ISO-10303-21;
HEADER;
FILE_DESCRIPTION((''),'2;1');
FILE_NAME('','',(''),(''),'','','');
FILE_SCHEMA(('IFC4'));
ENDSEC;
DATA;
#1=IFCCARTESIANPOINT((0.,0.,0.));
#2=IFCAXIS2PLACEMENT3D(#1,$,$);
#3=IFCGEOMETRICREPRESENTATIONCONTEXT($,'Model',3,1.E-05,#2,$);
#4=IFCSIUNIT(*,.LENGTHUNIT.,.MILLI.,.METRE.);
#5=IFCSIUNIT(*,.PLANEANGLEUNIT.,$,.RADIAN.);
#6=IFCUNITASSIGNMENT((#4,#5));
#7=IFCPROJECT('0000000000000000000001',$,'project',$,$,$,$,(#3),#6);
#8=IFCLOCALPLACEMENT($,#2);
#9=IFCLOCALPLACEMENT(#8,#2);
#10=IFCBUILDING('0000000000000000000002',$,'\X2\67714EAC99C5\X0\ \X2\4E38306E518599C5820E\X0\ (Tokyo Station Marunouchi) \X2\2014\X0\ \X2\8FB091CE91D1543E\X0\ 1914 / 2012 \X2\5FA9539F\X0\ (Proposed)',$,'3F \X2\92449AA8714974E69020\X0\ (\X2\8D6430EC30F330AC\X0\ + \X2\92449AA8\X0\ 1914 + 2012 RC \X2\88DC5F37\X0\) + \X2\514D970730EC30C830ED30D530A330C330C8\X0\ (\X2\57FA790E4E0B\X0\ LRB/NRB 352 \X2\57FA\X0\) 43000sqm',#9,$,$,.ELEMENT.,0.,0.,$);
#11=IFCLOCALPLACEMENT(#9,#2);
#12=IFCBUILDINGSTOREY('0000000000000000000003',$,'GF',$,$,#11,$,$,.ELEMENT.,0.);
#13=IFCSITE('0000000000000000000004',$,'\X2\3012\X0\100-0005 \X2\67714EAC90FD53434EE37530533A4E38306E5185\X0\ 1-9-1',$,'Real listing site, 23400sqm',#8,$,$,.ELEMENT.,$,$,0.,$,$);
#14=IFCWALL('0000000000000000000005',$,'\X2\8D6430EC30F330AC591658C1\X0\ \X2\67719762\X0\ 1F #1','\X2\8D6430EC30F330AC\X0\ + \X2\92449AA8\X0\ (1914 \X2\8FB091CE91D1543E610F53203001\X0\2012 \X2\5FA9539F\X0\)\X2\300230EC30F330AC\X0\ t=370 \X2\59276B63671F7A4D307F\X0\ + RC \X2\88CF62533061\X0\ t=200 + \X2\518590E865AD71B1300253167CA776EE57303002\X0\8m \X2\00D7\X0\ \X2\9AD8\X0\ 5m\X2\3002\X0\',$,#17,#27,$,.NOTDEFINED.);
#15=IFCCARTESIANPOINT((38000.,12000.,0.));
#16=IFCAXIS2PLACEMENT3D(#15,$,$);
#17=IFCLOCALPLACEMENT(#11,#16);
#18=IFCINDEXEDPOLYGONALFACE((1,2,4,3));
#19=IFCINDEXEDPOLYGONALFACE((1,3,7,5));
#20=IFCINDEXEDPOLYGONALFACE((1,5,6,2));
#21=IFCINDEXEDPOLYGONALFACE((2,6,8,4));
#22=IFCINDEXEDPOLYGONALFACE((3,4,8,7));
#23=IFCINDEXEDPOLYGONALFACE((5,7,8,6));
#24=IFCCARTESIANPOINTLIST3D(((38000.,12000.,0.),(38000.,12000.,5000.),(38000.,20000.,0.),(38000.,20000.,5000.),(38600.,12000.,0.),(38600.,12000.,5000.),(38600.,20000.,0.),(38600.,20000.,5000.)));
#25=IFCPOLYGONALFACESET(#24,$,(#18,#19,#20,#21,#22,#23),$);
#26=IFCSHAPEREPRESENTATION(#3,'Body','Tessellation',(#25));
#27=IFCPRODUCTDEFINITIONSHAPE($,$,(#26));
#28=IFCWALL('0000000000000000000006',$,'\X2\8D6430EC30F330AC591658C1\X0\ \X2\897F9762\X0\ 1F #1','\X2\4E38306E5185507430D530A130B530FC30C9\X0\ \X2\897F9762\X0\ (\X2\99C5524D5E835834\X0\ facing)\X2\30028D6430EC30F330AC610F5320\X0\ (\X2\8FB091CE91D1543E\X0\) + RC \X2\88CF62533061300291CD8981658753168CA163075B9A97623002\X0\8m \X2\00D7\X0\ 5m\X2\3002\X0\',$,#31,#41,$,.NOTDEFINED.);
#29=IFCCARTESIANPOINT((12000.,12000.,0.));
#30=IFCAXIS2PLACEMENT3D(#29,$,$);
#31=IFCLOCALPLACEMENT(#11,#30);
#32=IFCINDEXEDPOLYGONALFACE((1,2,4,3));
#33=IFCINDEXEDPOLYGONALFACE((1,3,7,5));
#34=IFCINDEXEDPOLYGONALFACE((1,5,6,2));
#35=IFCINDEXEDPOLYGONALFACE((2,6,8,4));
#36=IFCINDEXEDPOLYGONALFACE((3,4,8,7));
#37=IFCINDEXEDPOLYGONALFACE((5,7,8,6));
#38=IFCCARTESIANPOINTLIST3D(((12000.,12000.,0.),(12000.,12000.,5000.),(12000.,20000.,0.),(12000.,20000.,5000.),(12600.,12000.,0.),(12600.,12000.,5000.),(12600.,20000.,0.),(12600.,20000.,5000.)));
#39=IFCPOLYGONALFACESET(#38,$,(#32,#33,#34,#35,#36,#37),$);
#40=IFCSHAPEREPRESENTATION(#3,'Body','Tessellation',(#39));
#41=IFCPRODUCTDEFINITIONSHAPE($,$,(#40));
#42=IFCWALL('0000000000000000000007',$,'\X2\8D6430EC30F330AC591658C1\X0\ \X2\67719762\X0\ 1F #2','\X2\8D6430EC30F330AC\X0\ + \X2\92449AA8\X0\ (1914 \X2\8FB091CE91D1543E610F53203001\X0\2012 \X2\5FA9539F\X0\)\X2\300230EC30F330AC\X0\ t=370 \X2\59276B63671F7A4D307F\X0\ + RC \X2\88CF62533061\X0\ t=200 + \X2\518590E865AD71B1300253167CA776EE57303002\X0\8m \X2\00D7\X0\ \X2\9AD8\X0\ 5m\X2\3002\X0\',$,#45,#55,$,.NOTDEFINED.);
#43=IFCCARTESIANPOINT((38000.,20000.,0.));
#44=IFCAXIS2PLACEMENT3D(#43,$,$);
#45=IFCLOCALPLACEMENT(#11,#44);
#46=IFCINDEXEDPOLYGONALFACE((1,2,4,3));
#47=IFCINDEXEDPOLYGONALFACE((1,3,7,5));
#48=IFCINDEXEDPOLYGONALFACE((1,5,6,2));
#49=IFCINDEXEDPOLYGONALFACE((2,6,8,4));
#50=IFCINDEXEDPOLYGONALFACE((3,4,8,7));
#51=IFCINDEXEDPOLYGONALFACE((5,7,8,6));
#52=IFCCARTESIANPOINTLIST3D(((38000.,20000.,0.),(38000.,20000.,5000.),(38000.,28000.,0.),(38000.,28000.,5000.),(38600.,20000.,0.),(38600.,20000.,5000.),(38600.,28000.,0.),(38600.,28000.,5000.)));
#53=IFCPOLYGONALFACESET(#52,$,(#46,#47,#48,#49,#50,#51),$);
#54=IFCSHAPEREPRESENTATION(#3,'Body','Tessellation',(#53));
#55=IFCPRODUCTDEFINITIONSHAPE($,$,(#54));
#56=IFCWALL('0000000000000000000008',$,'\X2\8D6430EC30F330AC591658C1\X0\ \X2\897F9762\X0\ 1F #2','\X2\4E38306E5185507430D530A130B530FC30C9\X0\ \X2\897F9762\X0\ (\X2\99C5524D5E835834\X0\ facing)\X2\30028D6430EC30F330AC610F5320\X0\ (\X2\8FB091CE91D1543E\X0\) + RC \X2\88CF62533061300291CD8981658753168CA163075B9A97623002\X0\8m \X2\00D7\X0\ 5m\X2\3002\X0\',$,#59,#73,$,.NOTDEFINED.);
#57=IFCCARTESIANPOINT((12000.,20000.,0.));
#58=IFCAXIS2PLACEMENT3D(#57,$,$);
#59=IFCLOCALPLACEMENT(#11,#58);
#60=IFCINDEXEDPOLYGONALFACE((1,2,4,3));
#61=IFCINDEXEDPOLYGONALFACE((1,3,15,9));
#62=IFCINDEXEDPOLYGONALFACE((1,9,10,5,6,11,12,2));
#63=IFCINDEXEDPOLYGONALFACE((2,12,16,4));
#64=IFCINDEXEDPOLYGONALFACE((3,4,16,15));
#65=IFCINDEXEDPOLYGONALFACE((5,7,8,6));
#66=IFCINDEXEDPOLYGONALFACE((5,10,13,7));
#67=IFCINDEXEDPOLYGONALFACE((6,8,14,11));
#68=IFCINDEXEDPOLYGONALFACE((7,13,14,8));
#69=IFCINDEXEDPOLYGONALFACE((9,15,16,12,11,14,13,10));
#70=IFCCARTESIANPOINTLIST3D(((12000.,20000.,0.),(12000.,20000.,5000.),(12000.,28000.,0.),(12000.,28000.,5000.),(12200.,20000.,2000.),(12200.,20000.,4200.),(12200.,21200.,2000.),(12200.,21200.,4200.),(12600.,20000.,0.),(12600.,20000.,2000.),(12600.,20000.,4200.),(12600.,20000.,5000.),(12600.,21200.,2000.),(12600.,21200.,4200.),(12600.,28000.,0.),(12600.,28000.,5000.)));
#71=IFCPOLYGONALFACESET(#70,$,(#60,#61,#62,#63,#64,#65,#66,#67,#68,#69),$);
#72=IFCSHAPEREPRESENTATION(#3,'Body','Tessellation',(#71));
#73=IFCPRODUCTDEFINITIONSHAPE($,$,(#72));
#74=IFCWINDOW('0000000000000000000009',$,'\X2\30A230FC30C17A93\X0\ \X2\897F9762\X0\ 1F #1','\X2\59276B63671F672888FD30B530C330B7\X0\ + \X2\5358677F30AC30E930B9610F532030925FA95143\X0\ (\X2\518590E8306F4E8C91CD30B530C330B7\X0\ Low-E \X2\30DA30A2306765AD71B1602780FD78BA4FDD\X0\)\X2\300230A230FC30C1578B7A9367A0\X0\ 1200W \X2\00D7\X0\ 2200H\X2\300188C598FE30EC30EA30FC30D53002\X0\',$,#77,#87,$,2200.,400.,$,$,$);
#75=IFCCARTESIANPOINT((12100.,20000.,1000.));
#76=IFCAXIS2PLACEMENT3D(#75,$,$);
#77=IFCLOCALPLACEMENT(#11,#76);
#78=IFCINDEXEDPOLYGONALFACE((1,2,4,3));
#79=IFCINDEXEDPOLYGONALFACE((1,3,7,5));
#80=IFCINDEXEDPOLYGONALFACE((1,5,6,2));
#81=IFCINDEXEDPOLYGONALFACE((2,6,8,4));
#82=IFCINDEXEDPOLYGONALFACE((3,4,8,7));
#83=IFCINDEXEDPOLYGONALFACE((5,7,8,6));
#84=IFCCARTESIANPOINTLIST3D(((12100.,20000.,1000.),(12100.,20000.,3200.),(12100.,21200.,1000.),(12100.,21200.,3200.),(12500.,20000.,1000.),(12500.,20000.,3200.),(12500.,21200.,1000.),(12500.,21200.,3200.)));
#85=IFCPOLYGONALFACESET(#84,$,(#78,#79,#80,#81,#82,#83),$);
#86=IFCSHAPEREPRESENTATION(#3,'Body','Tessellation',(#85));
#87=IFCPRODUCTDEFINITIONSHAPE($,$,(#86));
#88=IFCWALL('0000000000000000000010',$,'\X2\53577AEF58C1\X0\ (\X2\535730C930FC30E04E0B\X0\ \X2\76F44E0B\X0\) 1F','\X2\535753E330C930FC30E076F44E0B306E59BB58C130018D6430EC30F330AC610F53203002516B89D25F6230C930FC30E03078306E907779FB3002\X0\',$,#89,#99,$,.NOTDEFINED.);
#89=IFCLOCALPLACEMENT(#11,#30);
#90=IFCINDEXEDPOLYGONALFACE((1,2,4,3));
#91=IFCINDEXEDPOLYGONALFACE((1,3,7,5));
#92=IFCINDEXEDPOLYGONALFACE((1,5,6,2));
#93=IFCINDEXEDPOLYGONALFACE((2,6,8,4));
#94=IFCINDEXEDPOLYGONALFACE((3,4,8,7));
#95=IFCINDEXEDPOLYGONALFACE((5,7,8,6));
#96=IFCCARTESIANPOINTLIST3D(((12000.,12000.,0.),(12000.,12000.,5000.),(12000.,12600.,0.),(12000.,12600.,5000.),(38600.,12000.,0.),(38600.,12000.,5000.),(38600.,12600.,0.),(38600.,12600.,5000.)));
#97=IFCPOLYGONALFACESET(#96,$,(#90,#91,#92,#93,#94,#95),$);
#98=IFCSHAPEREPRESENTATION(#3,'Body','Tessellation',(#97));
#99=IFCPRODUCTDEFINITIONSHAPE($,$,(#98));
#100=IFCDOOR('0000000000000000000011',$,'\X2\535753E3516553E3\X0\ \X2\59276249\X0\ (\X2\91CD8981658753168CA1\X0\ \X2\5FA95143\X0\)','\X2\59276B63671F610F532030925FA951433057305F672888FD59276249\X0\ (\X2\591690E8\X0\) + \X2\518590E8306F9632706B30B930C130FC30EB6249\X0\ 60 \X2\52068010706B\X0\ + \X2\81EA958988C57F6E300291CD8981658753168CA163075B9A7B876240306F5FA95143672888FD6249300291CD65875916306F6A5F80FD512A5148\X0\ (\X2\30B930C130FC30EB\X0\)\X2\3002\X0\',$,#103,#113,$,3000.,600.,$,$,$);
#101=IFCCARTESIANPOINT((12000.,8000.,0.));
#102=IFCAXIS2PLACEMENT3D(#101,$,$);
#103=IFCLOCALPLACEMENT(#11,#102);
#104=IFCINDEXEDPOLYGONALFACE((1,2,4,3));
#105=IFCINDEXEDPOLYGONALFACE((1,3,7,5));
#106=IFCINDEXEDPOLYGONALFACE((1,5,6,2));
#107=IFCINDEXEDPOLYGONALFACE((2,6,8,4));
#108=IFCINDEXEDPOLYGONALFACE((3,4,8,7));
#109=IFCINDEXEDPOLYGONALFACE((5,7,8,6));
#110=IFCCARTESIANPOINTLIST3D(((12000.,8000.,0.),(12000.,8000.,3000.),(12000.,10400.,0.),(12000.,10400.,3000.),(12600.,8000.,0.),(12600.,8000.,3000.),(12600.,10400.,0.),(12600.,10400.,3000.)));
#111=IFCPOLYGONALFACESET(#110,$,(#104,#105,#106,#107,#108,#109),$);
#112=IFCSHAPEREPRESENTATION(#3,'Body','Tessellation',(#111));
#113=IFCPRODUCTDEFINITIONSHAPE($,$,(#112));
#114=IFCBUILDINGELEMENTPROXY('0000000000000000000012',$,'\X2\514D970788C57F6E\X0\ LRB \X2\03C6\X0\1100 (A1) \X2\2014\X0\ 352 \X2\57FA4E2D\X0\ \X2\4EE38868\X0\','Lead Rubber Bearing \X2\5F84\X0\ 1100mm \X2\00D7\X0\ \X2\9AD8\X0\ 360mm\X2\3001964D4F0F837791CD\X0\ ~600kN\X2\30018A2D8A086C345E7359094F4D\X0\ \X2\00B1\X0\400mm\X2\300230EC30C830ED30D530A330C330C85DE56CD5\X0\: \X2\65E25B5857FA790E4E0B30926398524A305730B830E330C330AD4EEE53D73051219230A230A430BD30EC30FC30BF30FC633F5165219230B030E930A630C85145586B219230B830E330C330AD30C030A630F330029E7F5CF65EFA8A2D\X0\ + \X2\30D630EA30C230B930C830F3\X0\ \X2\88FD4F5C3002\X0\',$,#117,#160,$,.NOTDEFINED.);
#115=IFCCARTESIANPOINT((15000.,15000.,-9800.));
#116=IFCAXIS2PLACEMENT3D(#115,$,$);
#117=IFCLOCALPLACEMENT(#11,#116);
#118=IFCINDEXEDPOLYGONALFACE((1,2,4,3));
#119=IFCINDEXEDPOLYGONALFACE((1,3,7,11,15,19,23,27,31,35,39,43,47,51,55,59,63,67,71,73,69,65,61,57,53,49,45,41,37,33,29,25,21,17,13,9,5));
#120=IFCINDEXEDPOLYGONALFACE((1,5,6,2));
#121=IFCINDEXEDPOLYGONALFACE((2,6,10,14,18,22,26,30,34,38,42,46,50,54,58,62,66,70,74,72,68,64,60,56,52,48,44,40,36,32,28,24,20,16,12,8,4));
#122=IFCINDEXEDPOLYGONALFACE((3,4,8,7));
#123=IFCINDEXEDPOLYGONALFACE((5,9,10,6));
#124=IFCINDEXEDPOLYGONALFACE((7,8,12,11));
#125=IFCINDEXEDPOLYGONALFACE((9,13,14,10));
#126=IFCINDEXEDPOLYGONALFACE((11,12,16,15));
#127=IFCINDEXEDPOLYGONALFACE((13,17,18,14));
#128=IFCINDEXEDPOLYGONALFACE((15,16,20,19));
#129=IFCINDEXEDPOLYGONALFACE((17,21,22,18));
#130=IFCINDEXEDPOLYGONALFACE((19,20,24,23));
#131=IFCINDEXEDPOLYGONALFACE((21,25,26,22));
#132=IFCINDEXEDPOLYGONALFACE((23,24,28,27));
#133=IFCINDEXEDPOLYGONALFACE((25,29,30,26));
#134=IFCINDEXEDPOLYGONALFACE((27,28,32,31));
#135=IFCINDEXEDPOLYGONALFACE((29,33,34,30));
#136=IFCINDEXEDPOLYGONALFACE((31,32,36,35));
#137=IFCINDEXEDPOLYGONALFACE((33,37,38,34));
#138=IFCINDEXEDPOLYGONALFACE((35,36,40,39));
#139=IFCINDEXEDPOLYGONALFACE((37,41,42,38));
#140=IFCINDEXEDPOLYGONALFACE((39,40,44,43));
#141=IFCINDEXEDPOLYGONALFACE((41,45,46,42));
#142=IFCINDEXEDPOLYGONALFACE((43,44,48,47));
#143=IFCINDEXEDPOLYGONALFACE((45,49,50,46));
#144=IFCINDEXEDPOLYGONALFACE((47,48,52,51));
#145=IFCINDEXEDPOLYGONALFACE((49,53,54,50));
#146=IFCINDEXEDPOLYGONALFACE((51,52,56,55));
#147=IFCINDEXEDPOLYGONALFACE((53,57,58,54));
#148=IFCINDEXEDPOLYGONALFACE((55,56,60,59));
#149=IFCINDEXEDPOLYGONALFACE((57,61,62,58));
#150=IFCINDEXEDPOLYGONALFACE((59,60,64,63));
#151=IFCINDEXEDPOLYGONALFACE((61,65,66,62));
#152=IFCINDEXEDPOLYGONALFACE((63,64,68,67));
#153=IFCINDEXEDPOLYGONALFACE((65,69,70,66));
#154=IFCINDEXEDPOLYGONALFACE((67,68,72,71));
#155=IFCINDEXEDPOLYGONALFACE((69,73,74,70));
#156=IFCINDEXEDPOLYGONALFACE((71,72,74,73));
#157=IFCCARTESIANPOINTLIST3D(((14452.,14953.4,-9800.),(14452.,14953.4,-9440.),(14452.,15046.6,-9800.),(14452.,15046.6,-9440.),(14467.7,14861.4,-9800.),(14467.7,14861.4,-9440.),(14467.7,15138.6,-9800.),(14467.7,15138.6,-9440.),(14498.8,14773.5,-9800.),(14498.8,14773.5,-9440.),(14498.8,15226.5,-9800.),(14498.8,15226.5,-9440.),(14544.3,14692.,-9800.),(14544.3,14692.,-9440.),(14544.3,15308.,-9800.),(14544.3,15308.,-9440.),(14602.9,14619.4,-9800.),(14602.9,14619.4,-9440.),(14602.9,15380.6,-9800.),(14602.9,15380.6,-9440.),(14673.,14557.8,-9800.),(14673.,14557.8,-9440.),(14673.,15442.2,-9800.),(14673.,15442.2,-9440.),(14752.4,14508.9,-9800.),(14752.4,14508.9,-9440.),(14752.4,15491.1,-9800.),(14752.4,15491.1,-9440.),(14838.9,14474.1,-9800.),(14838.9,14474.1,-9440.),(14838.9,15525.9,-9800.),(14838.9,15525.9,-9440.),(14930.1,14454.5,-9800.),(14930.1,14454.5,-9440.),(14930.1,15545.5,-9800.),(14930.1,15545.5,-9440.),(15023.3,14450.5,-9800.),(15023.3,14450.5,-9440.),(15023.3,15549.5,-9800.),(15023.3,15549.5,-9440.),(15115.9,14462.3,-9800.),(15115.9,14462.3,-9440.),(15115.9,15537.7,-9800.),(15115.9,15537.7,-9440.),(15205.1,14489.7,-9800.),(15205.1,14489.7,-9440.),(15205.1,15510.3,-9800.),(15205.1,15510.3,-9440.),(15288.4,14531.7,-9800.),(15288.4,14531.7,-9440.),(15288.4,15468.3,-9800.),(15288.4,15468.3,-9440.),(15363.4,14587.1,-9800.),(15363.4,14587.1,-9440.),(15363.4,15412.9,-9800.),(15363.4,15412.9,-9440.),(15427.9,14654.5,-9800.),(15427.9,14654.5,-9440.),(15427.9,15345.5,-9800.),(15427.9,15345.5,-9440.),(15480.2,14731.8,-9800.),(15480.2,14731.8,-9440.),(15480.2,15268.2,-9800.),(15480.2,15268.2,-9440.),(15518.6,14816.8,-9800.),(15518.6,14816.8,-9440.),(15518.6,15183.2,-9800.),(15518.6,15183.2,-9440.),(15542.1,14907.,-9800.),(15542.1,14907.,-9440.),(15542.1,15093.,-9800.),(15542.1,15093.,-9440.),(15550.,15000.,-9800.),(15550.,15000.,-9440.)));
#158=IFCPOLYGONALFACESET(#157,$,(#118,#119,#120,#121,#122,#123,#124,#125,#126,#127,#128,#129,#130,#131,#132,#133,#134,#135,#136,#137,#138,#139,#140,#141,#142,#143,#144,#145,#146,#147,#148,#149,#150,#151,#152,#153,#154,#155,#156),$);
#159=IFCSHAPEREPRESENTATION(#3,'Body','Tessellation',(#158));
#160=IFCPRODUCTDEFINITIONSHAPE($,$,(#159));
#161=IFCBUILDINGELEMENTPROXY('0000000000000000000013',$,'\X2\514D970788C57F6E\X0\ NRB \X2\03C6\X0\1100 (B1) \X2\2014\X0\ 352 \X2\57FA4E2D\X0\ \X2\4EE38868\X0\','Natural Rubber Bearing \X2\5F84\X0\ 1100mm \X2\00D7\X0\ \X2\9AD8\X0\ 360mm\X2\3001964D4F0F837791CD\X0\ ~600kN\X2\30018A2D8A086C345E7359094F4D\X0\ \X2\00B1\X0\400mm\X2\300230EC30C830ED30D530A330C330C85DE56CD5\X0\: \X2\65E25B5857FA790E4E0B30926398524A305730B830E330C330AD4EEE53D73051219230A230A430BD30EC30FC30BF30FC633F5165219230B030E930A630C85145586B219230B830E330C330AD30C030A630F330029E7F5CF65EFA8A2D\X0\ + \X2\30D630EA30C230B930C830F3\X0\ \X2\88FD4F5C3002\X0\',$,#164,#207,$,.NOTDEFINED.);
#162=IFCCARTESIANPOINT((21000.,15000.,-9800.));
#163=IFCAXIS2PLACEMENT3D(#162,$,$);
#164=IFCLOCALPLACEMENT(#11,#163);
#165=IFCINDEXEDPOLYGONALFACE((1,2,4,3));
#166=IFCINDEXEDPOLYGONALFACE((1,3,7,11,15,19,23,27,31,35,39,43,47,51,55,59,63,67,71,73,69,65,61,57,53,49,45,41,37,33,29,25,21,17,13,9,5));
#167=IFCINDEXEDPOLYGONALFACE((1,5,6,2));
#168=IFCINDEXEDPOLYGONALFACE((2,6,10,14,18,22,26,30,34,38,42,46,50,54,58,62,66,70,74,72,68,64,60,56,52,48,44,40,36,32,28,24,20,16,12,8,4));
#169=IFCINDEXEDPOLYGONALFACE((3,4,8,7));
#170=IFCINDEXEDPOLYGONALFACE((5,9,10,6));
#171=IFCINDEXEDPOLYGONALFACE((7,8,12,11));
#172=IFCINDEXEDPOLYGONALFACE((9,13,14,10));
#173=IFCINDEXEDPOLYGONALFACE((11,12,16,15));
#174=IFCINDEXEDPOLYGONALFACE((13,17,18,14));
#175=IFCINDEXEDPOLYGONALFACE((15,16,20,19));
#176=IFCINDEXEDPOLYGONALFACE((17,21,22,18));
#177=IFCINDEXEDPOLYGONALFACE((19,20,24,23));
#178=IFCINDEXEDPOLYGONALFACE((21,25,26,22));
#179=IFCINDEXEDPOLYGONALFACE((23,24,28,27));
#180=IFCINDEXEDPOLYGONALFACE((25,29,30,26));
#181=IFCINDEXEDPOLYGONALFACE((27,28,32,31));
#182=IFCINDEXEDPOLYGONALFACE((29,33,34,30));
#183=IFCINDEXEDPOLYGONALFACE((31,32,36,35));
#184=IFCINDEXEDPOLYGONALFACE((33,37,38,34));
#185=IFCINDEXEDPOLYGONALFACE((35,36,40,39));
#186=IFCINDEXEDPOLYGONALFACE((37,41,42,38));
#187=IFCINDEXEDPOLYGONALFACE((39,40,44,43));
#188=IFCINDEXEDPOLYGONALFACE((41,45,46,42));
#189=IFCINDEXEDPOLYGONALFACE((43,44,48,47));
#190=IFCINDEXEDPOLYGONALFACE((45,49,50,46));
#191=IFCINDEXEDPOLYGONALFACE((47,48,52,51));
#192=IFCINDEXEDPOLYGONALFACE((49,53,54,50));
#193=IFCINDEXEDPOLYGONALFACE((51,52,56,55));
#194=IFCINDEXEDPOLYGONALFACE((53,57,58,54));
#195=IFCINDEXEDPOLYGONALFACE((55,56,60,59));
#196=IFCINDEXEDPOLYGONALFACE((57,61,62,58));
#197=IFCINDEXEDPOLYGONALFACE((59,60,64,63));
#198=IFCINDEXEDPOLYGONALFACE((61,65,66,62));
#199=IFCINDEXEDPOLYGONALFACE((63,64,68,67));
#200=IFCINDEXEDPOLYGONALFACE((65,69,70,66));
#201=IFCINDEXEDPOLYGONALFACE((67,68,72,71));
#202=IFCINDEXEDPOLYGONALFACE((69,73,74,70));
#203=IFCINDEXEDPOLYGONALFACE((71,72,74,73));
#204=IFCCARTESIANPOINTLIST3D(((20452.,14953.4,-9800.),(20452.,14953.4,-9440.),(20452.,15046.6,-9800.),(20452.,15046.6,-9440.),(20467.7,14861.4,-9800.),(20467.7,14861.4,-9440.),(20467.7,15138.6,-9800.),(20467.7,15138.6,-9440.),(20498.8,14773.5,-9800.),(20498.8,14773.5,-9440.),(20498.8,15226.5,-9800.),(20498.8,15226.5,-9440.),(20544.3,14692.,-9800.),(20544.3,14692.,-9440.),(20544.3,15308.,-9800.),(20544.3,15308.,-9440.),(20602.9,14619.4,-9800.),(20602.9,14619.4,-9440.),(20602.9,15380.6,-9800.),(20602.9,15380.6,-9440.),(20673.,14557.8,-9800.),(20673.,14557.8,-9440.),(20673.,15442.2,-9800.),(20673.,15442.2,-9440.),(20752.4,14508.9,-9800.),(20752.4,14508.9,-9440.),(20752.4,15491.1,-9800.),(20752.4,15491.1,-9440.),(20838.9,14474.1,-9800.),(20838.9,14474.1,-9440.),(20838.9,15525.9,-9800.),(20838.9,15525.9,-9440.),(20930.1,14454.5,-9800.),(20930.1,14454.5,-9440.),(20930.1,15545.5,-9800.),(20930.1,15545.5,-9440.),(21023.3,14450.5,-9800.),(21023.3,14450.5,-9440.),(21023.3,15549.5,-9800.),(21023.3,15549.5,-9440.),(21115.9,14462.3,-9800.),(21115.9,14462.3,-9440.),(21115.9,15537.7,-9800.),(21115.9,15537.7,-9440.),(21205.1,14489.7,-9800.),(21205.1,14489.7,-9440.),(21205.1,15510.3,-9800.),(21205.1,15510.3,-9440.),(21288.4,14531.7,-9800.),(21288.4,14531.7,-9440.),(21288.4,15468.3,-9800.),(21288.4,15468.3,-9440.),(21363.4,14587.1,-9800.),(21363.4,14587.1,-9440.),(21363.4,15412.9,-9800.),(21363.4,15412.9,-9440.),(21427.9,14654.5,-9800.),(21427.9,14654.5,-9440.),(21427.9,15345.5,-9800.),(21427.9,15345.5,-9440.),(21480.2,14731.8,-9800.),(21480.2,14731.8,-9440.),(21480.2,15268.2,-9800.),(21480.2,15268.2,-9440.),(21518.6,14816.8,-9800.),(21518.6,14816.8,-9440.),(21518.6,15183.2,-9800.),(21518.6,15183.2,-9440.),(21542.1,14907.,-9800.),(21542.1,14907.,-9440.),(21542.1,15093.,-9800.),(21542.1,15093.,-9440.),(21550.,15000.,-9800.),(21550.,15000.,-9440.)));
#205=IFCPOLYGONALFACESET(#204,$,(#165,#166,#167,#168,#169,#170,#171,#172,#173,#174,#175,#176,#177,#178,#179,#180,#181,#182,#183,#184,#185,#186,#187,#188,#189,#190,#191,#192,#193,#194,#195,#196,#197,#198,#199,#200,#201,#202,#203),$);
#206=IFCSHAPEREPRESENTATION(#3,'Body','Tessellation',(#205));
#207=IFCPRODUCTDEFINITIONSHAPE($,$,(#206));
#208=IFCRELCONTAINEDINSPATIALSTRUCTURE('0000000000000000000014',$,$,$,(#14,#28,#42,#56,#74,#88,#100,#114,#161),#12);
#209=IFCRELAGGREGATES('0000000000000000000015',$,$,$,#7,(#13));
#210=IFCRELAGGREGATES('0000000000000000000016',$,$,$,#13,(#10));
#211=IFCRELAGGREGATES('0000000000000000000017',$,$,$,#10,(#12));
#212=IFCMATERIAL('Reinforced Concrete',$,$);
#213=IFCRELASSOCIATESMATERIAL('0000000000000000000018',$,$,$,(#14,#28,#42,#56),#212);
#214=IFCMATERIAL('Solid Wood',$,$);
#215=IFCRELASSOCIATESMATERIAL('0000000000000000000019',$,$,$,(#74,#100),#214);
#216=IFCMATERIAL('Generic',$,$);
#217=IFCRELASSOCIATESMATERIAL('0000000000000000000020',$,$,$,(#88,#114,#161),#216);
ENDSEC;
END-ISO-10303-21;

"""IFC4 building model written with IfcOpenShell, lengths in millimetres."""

from ifc_helpers import new_model, si_unit, frame, frame_2d, origin, origin_2d, place, context, project, spatial, rectangle, circle, extrude, material, element, fill, save


model = new_model("IFC4")

# Units and contexts
model_context = context("Model", 3, precision=1e-05, world=origin())
ifc_project = project(units=[si_unit("LENGTHUNIT", "METRE", prefix="MILLI"), si_unit("PLANEANGLEUNIT", "RADIAN")], contexts=[model_context])

# Site, building, storey
site_placement = place(None, origin())
site = spatial("IfcSite", under=ifc_project, at=site_placement, Name="〒100-0005 東京都千代田区丸の内 1-9-1", ObjectType="Real listing site, 23400sqm", CompositionType="ELEMENT", RefElevation=0.0)
building_placement = place(site_placement, origin())
building = spatial("IfcBuilding", under=site, at=building_placement, Name="東京駅 丸の内駅舎 (Tokyo Station Marunouchi) — 辰野金吾 1914 / 2012 復原 (Proposed)", ObjectType="3F 鉄骨煉瓦造 (赤レンガ + 鉄骨 1914 + 2012 RC 補強) + 免震レトロフィット (基礎下 LRB/NRB 352 基) 43000sqm", CompositionType="ELEMENT", ElevationOfRefHeight=0.0, ElevationOfTerrain=0.0)
storey_placement = place(building_placement, origin())
storey = spatial("IfcBuildingStorey", under=building, at=storey_placement, Name="GF", CompositionType="ELEMENT", Elevation=0.0)

# Shared definitions
ifc_material_1 = material(Name="Reinforced Concrete")

# Walls
wall_1_placement = place(storey_placement, frame((38000.0, 12000.0, 0.0)))
element("IfcWall", 1, at=wall_1_placement, inside=storey, material=ifc_material_1, Name="赤レンガ外壁 東面 1F #1", Description="赤レンガ + 鉄骨 (1914 辰野金吾意匠、2012 復原)。レンガ t=370 大正期積み + RC 裏打ち t=200 + 内部断熱。化粧目地。8m × 高 5m。", PredefinedType="NOTDEFINED", context=model_context, shape_type="SweptSolid", body=[
    extrude(rectangle(XDim=600.0, YDim=8000.0, at=frame_2d((300.0, 4000.0))), frame((38000.0, 12000.0, 0.0)), (0.0, 0.0, 1.0), 5000.0),
])
wall_2_placement = place(storey_placement, frame((12000.0, 12000.0, 0.0)))
element("IfcWall", 2, at=wall_2_placement, inside=storey, material=ifc_material_1, Name="赤レンガ外壁 西面 1F #1", Description="丸の内側ファサード 西面 (駅前広場 facing)。赤レンガ意匠 (辰野金吾) + RC 裏打ち。重要文化財指定面。8m × 5m。", PredefinedType="NOTDEFINED", context=model_context, shape_type="SweptSolid", body=[
    extrude(rectangle(XDim=600.0, YDim=8000.0, at=frame_2d((300.0, 4000.0))), frame((12000.0, 12000.0, 0.0)), (0.0, 0.0, 1.0), 5000.0),
])
wall_3_placement = place(storey_placement, frame((38000.0, 20000.0, 0.0)))
element("IfcWall", 3, at=wall_3_placement, inside=storey, material=ifc_material_1, Name="赤レンガ外壁 東面 1F #2", Description="赤レンガ + 鉄骨 (1914 辰野金吾意匠、2012 復原)。レンガ t=370 大正期積み + RC 裏打ち t=200 + 内部断熱。化粧目地。8m × 高 5m。", PredefinedType="NOTDEFINED", context=model_context, shape_type="SweptSolid", body=[
    extrude(rectangle(XDim=600.0, YDim=8000.0, at=frame_2d((300.0, 4000.0))), frame((38000.0, 20000.0, 0.0)), (0.0, 0.0, 1.0), 5000.0),
])

# Wall, opening, window
wall_4_placement = place(storey_placement, frame((12000.0, 20000.0, 0.0)))
wall_4 = element("IfcWall", 4, at=wall_4_placement, inside=storey, material=ifc_material_1, Name="赤レンガ外壁 西面 1F #2", Description="丸の内側ファサード 西面 (駅前広場 facing)。赤レンガ意匠 (辰野金吾) + RC 裏打ち。重要文化財指定面。8m × 5m。", PredefinedType="NOTDEFINED", context=model_context, shape_type="SweptSolid", body=[
    extrude(rectangle(XDim=600.0, YDim=8000.0, at=frame_2d((300.0, 4000.0))), frame((12000.0, 20000.0, 0.0)), (0.0, 0.0, 1.0), 5000.0),
])
opening_placement = place(storey_placement, frame((12100.0, 20000.0, 1000.0)))
opening = element("IfcOpeningElement", 5, at=opening_placement, cuts=wall_4, PredefinedType="NOTDEFINED", context=model_context, shape_type="SweptSolid", body=[
    extrude(rectangle(XDim=400.0, YDim=1200.0, at=frame_2d((200.0, 600.0))), frame((12100.0, 20000.0, 1000.0)), (0.0, 0.0, 1.0), 2200.0),
])
ifc_material_2 = material(Name="Solid Wood")
window_placement = place(storey_placement, frame((12100.0, 20000.0, 1000.0)))
window = element("IfcWindow", 6, at=window_placement, inside=storey, material=ifc_material_2, Name="アーチ窓 西面 1F #1", Description="大正期木製サッシ + 単板ガラス意匠を復元 (内部は二重サッシ Low-E ペアで断熱性能確保)。アーチ型窓枠 1200W × 2200H、装飾レリーフ。", OverallHeight=2200.0, OverallWidth=400.0, context=model_context, shape_type="SweptSolid", body=[
    extrude(rectangle(XDim=400.0, YDim=1200.0, at=frame_2d((200.0, 600.0))), frame((12100.0, 20000.0, 1000.0)), (0.0, 0.0, 1.0), 2200.0),
])
fill(opening, window)

# Wall
ifc_material_3 = material(Name="Generic")
wall_5_placement = place(storey_placement, frame((12000.0, 12000.0, 0.0)))
element("IfcWall", 7, at=wall_5_placement, inside=storey, material=ifc_material_3, Name="南端壁 (南ドーム下 直下) 1F", Description="南口ドーム直下の妻壁、赤レンガ意匠。八角形ドームへの遷移。", PredefinedType="NOTDEFINED", context=model_context, shape_type="SweptSolid", body=[
    extrude(rectangle(XDim=26600.0, YDim=600.0, at=frame_2d((13300.0, 300.0))), frame((12000.0, 12000.0, 0.0)), (0.0, 0.0, 1.0), 5000.0),
])

# Door
door_placement = place(storey_placement, frame((12000.0, 8000.0, 0.0)))
element("IfcDoor", 8, at=door_placement, inside=storey, material=ifc_material_2, Name="南口入口 大扉 (重要文化財 復元)", Description="大正期意匠を復元した木製大扉 (外部) + 内部は防火スチール扉 60 分耐火 + 自閉装置。重要文化財指定箇所は復元木製扉。重文外は機能優先 (スチール)。", OverallHeight=3000.0, OverallWidth=600.0, context=model_context, shape_type="SweptSolid", body=[
    extrude(rectangle(XDim=600.0, YDim=2400.0, at=frame_2d((300.0, 1200.0))), frame((12000.0, 8000.0, 0.0)), (0.0, 0.0, 1.0), 3000.0),
])

# Building element proxies
proxy_1_placement = place(storey_placement, frame((15000.0, 15000.0, -9800.0)))
element("IfcBuildingElementProxy", 9, at=proxy_1_placement, inside=storey, material=ifc_material_3, Name="免震装置 LRB φ1100 (A1) — 352 基中 代表", Description="Lead Rubber Bearing 径 1100mm × 高 360mm、降伏荷重 ~600kN、設計水平変位 ±400mm。レトロフィット工法: 既存基礎下を掘削しジャッキ仮受け→アイソレーター挿入→グラウト充填→ジャッキダウン。鹿島建設 + ブリヂストン 製作。", PredefinedType="NOTDEFINED", context=model_context, shape_type="SweptSolid", body=[
    extrude(circle(Radius=550.0, at=origin_2d()), frame((15000.0, 15000.0, -9800.0)), (0.0, 0.0, 1.0), 360.0),
])
proxy_2_placement = place(storey_placement, frame((21000.0, 15000.0, -9800.0)))
element("IfcBuildingElementProxy", 10, at=proxy_2_placement, inside=storey, material=ifc_material_3, Name="免震装置 NRB φ1100 (B1) — 352 基中 代表", Description="Natural Rubber Bearing 径 1100mm × 高 360mm、降伏荷重 ~600kN、設計水平変位 ±400mm。レトロフィット工法: 既存基礎下を掘削しジャッキ仮受け→アイソレーター挿入→グラウト充填→ジャッキダウン。鹿島建設 + ブリヂストン 製作。", PredefinedType="NOTDEFINED", context=model_context, shape_type="SweptSolid", body=[
    extrude(circle(Radius=550.0, at=origin_2d()), frame((21000.0, 15000.0, -9800.0)), (0.0, 0.0, 1.0), 360.0),
])

save(model, "model.ifc")
